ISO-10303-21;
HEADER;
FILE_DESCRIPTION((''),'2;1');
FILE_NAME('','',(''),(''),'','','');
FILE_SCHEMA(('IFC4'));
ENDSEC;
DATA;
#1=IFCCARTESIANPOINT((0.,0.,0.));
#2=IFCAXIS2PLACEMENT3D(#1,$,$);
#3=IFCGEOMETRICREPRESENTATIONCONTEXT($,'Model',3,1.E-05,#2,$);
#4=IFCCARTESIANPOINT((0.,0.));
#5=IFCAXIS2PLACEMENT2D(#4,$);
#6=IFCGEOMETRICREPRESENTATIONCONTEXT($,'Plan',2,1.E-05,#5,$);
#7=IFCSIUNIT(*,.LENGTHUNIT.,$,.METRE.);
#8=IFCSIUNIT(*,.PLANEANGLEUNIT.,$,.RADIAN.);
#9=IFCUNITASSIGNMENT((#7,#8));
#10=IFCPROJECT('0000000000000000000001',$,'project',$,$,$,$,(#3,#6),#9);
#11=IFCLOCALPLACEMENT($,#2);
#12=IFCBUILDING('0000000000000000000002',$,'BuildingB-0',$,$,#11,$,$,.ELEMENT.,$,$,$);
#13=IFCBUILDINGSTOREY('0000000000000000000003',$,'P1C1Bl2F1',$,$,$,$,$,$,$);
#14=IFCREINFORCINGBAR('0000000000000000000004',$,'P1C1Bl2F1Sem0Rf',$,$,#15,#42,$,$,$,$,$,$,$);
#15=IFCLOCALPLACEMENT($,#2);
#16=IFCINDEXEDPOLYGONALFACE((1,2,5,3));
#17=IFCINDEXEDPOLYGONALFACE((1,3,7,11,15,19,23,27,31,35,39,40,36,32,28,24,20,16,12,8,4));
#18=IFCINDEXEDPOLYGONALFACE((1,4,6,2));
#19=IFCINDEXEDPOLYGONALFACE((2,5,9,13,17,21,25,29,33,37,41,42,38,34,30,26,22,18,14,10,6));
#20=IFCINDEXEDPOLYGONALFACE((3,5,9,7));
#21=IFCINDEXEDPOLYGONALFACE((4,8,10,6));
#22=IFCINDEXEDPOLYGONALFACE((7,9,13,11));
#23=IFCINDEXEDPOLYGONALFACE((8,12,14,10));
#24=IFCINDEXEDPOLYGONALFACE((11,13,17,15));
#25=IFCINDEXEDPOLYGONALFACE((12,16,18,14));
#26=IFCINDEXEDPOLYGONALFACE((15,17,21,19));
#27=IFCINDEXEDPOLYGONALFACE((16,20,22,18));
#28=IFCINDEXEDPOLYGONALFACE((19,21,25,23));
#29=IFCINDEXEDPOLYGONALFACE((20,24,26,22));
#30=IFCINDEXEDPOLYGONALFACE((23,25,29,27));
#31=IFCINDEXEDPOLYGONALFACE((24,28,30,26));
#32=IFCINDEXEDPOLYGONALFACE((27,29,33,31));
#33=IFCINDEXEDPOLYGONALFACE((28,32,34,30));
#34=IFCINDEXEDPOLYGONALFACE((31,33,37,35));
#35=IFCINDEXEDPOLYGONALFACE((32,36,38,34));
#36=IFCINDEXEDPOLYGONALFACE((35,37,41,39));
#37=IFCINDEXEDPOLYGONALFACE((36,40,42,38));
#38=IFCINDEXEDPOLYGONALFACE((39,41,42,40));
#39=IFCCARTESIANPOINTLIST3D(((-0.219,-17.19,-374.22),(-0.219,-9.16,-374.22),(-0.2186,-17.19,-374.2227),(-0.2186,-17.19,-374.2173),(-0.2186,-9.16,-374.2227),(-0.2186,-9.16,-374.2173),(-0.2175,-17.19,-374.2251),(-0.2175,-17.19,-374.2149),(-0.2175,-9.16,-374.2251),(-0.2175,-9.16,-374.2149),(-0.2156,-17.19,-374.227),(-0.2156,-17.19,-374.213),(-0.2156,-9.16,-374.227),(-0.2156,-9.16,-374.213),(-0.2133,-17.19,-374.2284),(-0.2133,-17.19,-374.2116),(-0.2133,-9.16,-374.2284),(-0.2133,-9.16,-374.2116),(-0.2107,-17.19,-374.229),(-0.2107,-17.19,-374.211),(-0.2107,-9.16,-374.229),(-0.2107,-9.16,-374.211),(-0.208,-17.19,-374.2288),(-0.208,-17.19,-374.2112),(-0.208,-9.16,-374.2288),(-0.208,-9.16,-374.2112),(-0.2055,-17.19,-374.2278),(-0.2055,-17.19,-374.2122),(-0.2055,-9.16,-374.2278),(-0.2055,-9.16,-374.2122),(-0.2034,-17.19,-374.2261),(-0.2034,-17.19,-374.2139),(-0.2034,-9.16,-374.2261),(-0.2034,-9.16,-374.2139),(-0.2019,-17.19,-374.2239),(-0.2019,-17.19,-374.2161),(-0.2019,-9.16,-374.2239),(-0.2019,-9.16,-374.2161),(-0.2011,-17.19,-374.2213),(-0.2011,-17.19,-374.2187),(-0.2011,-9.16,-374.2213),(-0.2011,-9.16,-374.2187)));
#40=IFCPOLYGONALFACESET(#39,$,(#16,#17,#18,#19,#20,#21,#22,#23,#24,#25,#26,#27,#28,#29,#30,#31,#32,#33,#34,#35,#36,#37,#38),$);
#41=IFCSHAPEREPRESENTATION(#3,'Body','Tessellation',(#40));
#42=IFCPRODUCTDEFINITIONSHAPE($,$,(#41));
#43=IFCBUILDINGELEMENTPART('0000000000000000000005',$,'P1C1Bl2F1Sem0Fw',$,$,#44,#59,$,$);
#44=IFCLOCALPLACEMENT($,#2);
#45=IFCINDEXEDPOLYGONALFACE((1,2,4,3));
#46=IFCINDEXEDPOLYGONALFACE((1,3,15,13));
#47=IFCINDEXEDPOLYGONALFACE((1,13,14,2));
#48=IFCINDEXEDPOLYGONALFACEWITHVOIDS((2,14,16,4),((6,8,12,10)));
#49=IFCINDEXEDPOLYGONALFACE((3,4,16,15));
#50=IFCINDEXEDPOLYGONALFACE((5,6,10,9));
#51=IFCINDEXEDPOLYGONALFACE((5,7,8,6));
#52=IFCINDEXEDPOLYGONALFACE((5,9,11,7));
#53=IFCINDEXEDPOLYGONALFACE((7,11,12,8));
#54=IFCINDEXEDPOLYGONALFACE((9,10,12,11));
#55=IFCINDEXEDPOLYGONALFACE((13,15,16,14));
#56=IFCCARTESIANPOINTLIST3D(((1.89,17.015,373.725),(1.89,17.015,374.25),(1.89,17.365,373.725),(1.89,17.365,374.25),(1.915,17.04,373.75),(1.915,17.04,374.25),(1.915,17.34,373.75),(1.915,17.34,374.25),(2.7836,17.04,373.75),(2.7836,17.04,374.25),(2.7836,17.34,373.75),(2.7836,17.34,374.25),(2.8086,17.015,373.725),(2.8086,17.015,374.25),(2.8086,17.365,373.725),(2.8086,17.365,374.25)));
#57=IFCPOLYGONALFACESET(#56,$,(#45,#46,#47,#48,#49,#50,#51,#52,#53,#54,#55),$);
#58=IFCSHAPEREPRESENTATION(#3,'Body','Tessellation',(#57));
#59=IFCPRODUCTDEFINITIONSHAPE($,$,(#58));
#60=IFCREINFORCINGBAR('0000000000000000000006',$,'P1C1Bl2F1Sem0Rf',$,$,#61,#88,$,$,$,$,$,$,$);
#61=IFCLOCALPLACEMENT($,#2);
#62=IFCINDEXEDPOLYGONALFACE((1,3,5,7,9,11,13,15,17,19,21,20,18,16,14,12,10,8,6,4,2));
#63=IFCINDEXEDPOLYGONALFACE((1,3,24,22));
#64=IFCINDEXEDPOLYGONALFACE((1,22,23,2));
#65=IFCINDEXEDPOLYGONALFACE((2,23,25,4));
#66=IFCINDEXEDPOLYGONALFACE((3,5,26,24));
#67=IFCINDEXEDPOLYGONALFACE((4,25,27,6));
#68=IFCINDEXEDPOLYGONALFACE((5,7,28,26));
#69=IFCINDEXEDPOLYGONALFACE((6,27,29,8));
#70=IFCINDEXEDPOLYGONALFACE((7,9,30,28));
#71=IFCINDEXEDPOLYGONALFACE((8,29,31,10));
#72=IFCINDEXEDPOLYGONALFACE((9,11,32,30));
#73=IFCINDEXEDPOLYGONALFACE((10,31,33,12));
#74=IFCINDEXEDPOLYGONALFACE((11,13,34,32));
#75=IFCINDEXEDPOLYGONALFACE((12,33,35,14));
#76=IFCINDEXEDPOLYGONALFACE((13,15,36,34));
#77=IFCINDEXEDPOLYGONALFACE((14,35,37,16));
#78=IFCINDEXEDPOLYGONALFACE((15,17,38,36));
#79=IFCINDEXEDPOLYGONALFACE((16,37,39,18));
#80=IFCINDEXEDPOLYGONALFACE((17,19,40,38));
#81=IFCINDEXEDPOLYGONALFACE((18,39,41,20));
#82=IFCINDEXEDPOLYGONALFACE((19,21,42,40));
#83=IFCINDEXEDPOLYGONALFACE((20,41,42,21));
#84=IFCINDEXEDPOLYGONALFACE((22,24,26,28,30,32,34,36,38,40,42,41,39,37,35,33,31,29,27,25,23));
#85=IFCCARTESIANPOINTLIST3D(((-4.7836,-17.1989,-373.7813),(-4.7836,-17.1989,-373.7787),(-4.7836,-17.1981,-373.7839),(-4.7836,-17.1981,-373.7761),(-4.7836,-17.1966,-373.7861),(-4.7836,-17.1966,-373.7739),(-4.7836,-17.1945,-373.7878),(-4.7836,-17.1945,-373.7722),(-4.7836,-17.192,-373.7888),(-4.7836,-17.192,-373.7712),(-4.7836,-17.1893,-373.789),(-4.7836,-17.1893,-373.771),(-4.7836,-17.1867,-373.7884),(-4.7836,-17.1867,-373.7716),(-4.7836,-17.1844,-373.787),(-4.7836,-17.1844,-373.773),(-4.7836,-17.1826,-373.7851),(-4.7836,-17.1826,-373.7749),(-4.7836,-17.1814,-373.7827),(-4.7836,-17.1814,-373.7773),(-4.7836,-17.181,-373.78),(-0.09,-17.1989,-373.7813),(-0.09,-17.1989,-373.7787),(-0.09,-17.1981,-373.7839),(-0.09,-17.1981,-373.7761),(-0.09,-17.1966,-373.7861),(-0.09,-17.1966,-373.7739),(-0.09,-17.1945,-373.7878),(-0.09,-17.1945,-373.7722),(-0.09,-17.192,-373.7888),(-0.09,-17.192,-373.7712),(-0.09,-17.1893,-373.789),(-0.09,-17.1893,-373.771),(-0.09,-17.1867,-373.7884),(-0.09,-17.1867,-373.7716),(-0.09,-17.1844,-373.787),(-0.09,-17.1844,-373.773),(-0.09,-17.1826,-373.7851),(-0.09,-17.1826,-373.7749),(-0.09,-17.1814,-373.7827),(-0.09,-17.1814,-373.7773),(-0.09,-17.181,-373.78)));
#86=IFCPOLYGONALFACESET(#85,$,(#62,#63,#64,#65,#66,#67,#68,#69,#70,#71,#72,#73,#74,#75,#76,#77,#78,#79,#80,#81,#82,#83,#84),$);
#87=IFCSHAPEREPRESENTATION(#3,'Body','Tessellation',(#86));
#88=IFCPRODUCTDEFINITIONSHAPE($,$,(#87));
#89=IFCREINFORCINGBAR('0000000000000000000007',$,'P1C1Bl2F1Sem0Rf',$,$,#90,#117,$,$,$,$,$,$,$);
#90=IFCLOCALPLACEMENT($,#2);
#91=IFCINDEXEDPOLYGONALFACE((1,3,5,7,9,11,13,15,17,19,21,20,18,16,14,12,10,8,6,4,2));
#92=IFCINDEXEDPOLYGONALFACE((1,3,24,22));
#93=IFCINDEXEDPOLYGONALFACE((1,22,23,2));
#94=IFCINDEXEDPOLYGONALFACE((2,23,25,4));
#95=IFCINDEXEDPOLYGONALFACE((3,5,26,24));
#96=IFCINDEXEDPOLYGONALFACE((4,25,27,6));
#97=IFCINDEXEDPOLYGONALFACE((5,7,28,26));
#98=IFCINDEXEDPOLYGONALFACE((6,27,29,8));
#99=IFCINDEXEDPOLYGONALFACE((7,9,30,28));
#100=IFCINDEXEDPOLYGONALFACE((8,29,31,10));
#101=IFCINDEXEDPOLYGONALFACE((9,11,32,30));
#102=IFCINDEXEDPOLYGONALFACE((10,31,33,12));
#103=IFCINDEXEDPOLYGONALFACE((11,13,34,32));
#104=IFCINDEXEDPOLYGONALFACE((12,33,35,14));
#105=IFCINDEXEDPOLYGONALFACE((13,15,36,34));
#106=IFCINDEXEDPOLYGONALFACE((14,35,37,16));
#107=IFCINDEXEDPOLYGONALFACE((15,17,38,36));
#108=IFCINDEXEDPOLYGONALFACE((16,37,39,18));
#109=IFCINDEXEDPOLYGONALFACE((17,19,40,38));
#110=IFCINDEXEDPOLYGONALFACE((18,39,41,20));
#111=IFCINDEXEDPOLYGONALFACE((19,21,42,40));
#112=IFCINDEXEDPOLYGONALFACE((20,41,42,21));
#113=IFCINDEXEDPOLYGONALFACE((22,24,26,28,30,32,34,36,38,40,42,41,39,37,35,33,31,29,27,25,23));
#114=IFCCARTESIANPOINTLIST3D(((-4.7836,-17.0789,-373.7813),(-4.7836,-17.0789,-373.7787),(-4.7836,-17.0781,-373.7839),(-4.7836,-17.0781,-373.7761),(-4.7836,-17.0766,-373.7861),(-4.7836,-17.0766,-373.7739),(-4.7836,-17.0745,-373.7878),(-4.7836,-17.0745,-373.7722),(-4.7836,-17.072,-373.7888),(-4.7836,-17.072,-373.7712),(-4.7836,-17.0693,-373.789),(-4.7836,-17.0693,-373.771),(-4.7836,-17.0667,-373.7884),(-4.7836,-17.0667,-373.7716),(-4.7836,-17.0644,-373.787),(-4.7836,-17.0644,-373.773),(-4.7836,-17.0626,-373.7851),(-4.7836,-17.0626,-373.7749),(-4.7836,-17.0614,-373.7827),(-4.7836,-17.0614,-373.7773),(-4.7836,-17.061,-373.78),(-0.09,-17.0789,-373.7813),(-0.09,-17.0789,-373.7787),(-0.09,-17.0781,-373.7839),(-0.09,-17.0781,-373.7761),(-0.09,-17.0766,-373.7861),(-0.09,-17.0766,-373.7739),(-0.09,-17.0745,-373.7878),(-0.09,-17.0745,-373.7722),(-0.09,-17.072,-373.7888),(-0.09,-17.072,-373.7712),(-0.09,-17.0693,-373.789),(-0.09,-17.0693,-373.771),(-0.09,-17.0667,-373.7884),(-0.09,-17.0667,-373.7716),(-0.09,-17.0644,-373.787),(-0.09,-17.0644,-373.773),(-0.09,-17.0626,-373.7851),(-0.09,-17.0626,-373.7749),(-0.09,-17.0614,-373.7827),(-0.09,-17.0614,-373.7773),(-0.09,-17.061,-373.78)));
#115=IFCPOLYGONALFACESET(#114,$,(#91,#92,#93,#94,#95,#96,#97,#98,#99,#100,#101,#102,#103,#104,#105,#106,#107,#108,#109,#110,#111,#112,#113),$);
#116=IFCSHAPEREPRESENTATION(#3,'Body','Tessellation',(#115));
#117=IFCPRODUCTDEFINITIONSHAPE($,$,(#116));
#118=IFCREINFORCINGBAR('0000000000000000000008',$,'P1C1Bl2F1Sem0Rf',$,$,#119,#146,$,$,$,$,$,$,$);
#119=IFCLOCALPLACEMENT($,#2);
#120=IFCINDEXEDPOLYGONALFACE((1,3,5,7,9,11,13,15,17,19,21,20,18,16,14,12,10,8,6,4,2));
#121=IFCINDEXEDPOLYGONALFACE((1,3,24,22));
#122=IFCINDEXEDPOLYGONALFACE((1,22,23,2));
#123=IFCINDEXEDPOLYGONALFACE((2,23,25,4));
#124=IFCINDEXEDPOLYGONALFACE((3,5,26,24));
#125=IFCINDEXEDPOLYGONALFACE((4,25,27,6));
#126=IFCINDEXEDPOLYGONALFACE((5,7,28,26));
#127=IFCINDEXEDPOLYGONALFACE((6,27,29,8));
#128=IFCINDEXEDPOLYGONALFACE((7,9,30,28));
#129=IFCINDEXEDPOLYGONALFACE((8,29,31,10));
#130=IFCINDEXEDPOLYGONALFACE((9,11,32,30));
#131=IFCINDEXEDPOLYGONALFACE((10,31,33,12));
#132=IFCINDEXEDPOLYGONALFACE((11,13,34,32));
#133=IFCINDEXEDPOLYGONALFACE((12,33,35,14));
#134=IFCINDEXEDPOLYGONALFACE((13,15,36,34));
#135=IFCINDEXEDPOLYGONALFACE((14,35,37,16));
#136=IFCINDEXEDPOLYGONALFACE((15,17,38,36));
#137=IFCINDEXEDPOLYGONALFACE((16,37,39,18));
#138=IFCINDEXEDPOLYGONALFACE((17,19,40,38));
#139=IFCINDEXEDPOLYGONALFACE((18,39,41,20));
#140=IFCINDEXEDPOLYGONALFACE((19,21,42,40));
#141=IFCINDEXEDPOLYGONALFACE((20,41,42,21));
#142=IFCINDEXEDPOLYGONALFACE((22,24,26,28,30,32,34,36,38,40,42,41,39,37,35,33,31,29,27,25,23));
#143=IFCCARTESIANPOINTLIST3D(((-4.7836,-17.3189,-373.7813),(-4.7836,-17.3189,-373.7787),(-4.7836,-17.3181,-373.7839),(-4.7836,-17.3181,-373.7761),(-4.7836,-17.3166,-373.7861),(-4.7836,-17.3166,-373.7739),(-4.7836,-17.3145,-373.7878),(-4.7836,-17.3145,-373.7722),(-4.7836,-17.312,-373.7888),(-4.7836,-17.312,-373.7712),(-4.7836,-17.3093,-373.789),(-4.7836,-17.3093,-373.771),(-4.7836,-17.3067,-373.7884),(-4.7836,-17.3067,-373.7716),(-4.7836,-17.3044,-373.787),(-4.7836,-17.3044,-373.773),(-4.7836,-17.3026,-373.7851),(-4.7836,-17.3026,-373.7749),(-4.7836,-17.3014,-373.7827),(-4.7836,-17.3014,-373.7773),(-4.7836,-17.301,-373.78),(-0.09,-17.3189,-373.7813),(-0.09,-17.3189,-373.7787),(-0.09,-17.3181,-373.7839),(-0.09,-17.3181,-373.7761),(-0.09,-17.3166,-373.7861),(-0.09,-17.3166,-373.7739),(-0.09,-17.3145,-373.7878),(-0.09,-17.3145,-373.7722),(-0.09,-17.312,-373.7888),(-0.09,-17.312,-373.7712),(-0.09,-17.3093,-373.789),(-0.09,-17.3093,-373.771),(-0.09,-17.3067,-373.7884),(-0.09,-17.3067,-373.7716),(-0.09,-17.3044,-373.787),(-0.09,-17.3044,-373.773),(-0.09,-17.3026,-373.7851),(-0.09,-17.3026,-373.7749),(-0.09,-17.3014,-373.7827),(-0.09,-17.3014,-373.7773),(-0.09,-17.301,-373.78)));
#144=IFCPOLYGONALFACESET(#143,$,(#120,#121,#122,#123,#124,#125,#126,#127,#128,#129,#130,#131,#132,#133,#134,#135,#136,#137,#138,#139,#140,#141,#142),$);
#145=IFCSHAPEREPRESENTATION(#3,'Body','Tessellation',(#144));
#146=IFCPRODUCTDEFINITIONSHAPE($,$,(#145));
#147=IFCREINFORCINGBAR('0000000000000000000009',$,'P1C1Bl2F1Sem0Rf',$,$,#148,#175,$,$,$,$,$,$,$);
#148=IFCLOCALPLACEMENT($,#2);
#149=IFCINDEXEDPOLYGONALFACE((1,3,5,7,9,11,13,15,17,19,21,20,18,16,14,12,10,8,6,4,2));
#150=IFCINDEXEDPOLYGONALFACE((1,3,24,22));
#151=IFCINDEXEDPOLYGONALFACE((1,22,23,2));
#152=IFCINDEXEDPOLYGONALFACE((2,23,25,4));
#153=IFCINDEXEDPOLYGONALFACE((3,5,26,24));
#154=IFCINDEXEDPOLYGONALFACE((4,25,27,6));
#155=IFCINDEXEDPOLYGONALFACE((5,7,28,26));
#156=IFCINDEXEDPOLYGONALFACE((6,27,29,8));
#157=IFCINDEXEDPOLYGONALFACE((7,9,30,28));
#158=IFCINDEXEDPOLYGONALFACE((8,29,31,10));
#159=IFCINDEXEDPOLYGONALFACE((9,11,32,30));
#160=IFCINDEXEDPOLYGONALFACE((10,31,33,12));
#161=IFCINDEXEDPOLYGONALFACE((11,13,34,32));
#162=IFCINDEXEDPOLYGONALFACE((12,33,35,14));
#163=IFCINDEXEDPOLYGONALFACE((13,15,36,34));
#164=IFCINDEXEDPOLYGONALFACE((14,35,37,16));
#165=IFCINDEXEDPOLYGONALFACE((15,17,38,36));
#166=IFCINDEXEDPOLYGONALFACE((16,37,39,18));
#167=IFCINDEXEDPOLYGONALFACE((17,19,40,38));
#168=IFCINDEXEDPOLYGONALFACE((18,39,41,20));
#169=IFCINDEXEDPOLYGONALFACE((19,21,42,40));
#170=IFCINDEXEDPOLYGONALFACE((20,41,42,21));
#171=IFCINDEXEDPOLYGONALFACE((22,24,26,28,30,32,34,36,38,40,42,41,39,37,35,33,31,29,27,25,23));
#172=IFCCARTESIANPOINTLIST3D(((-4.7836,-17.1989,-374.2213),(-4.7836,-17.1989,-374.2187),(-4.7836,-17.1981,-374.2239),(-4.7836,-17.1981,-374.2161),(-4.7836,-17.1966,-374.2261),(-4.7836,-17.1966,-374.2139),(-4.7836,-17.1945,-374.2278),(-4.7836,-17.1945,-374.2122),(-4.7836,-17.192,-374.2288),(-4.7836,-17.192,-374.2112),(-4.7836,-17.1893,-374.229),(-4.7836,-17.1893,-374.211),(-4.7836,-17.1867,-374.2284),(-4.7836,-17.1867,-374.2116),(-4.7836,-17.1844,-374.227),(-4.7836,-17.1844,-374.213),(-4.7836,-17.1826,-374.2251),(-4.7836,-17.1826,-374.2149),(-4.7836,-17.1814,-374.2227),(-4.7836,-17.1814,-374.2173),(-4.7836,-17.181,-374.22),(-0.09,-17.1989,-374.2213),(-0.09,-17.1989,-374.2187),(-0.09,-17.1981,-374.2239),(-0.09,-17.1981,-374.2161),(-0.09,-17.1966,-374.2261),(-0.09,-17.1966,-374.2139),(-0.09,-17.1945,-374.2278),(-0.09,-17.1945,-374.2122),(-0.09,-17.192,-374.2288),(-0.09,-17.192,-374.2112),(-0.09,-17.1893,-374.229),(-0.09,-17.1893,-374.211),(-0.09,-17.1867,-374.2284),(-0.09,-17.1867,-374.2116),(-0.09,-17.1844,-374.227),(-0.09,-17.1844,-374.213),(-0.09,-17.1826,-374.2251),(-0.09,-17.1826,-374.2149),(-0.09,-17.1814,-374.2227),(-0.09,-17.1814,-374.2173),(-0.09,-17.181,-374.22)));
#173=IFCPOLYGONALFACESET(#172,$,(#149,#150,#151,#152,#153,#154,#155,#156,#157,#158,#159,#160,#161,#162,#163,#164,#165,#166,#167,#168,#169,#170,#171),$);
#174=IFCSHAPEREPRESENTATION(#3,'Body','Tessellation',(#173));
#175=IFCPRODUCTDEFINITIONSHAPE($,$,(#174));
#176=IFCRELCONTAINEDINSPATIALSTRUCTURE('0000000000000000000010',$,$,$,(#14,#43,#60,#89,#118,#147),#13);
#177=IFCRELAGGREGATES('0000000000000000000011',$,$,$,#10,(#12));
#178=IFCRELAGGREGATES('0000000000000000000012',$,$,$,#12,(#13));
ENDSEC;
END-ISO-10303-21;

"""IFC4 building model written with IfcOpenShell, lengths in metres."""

from ifc_helpers import new_model, entity, si_unit, origin, origin_2d, place, context, project, spatial, polyline, outline, extrude, element, save


model = new_model("IFC4")

# Units and contexts
model_context = context("Model", 3, precision=1e-05, world=origin())
plan_context = context("Plan", 2, precision=1e-05, world=origin_2d())
ifc_project = project(units=[si_unit("LENGTHUNIT", "METRE"), si_unit("PLANEANGLEUNIT", "RADIAN")], contexts=[model_context, plan_context])

# Building, storey
building_placement = place(None, origin())
building = spatial("IfcBuilding", under=ifc_project, at=building_placement, Name="BuildingB-0", CompositionType="ELEMENT")
storey = spatial("IfcBuildingStorey", under=building, Name="P1C1Bl2F1")

# Reinforcing bar
element("IfcReinforcingBar", 1, inside=storey, Name="P1C1Bl2F1Sem0Rf", context=model_context, shape_type="SweptSolid", body=[
    entity("IfcSurfaceCurveSweptAreaSolid", entity("IfcCircleProfileDef", "AREA", None, None, 0.009), None, entity("IfcPolyline", [entity("IfcCartesianPoint", [0.21, 17.19, 374.22]), entity("IfcCartesianPoint", [0.21, 9.16, 374.22])]), None, None, entity("IfcPlane", entity("IfcAxis2Placement3D", entity("IfcCartesianPoint", [0.21, 17.19, 374.22]), entity("IfcDirection", [0.0, 0.0, 1.0]), entity("IfcDirection", [1.0, 0.0, 0.0])))),
])

# Building element part, opening
building_element_part_1 = element("IfcBuildingElementPart", 2, inside=storey, Name="P1C1Bl2F1Sem0Fw", context=model_context, shape_type="SweptSolid", body=[
    extrude(outline(polyline([(1.89, 17.015, 373.725), (1.89, 17.365, 373.725), (2.8086, 17.365, 373.725), (2.8086, 17.015, 373.725), (1.89, 17.015, 373.725)])), None, (0.0, 0.0, 1.0), 0.525),
])
element("IfcOpeningElement", 3, inside=storey, cuts=building_element_part_1, context=model_context, shape_type="SweptSolid", body=[
    extrude(outline(polyline([(1.915, 17.04, 373.75), (1.915, 17.34, 373.75), (2.7836, 17.34, 373.75), (2.7836, 17.04, 373.75), (1.915, 17.04, 373.75)])), None, (0.0, 0.0, 1.0), 0.5),
])

# Reinforcing bars
element("IfcReinforcingBar", 4, inside=storey, Name="P1C1Bl2F1Sem0Rf", context=model_context, shape_type="SweptSolid", body=[
    entity("IfcSurfaceCurveSweptAreaSolid", entity("IfcCircleProfileDef", "AREA", None, None, 0.009), None, entity("IfcPolyline", [entity("IfcCartesianPoint", [0.09, 17.19, 373.78]), entity("IfcCartesianPoint", [4.7836, 17.19, 373.78])]), None, None, entity("IfcPlane", entity("IfcAxis2Placement3D", entity("IfcCartesianPoint", [0.09, 17.19, 373.78]), entity("IfcDirection", [0.0, 0.0, 1.0]), entity("IfcDirection", [1.0, 0.0, 0.0])))),
])
element("IfcReinforcingBar", 5, inside=storey, Name="P1C1Bl2F1Sem0Rf", context=model_context, shape_type="SweptSolid", body=[
    entity("IfcSurfaceCurveSweptAreaSolid", entity("IfcCircleProfileDef", "AREA", None, None, 0.009), None, entity("IfcPolyline", [entity("IfcCartesianPoint", [0.09, 17.07, 373.78]), entity("IfcCartesianPoint", [4.7836, 17.07, 373.78])]), None, None, entity("IfcPlane", entity("IfcAxis2Placement3D", entity("IfcCartesianPoint", [0.09, 17.07, 373.78]), entity("IfcDirection", [0.0, 0.0, 1.0]), entity("IfcDirection", [1.0, 0.0, 0.0])))),
])
element("IfcReinforcingBar", 6, inside=storey, Name="P1C1Bl2F1Sem0Rf", context=model_context, shape_type="SweptSolid", body=[
    entity("IfcSurfaceCurveSweptAreaSolid", entity("IfcCircleProfileDef", "AREA", None, None, 0.009), None, entity("IfcPolyline", [entity("IfcCartesianPoint", [0.09, 17.31, 373.78]), entity("IfcCartesianPoint", [4.7836, 17.31, 373.78])]), None, None, entity("IfcPlane", entity("IfcAxis2Placement3D", entity("IfcCartesianPoint", [0.09, 17.31, 373.78]), entity("IfcDirection", [0.0, 0.0, 1.0]), entity("IfcDirection", [1.0, 0.0, 0.0])))),
])
element("IfcReinforcingBar", 7, inside=storey, Name="P1C1Bl2F1Sem0Rf", context=model_context, shape_type="SweptSolid", body=[
    entity("IfcSurfaceCurveSweptAreaSolid", entity("IfcCircleProfileDef", "AREA", None, None, 0.009), None, entity("IfcPolyline", [entity("IfcCartesianPoint", [0.09, 17.19, 374.22]), entity("IfcCartesianPoint", [4.7836, 17.19, 374.22])]), None, None, entity("IfcPlane", entity("IfcAxis2Placement3D", entity("IfcCartesianPoint", [0.09, 17.19, 374.22]), entity("IfcDirection", [0.0, 0.0, 1.0]), entity("IfcDirection", [1.0, 0.0, 0.0])))),
])

save(model, "model.ifc")
